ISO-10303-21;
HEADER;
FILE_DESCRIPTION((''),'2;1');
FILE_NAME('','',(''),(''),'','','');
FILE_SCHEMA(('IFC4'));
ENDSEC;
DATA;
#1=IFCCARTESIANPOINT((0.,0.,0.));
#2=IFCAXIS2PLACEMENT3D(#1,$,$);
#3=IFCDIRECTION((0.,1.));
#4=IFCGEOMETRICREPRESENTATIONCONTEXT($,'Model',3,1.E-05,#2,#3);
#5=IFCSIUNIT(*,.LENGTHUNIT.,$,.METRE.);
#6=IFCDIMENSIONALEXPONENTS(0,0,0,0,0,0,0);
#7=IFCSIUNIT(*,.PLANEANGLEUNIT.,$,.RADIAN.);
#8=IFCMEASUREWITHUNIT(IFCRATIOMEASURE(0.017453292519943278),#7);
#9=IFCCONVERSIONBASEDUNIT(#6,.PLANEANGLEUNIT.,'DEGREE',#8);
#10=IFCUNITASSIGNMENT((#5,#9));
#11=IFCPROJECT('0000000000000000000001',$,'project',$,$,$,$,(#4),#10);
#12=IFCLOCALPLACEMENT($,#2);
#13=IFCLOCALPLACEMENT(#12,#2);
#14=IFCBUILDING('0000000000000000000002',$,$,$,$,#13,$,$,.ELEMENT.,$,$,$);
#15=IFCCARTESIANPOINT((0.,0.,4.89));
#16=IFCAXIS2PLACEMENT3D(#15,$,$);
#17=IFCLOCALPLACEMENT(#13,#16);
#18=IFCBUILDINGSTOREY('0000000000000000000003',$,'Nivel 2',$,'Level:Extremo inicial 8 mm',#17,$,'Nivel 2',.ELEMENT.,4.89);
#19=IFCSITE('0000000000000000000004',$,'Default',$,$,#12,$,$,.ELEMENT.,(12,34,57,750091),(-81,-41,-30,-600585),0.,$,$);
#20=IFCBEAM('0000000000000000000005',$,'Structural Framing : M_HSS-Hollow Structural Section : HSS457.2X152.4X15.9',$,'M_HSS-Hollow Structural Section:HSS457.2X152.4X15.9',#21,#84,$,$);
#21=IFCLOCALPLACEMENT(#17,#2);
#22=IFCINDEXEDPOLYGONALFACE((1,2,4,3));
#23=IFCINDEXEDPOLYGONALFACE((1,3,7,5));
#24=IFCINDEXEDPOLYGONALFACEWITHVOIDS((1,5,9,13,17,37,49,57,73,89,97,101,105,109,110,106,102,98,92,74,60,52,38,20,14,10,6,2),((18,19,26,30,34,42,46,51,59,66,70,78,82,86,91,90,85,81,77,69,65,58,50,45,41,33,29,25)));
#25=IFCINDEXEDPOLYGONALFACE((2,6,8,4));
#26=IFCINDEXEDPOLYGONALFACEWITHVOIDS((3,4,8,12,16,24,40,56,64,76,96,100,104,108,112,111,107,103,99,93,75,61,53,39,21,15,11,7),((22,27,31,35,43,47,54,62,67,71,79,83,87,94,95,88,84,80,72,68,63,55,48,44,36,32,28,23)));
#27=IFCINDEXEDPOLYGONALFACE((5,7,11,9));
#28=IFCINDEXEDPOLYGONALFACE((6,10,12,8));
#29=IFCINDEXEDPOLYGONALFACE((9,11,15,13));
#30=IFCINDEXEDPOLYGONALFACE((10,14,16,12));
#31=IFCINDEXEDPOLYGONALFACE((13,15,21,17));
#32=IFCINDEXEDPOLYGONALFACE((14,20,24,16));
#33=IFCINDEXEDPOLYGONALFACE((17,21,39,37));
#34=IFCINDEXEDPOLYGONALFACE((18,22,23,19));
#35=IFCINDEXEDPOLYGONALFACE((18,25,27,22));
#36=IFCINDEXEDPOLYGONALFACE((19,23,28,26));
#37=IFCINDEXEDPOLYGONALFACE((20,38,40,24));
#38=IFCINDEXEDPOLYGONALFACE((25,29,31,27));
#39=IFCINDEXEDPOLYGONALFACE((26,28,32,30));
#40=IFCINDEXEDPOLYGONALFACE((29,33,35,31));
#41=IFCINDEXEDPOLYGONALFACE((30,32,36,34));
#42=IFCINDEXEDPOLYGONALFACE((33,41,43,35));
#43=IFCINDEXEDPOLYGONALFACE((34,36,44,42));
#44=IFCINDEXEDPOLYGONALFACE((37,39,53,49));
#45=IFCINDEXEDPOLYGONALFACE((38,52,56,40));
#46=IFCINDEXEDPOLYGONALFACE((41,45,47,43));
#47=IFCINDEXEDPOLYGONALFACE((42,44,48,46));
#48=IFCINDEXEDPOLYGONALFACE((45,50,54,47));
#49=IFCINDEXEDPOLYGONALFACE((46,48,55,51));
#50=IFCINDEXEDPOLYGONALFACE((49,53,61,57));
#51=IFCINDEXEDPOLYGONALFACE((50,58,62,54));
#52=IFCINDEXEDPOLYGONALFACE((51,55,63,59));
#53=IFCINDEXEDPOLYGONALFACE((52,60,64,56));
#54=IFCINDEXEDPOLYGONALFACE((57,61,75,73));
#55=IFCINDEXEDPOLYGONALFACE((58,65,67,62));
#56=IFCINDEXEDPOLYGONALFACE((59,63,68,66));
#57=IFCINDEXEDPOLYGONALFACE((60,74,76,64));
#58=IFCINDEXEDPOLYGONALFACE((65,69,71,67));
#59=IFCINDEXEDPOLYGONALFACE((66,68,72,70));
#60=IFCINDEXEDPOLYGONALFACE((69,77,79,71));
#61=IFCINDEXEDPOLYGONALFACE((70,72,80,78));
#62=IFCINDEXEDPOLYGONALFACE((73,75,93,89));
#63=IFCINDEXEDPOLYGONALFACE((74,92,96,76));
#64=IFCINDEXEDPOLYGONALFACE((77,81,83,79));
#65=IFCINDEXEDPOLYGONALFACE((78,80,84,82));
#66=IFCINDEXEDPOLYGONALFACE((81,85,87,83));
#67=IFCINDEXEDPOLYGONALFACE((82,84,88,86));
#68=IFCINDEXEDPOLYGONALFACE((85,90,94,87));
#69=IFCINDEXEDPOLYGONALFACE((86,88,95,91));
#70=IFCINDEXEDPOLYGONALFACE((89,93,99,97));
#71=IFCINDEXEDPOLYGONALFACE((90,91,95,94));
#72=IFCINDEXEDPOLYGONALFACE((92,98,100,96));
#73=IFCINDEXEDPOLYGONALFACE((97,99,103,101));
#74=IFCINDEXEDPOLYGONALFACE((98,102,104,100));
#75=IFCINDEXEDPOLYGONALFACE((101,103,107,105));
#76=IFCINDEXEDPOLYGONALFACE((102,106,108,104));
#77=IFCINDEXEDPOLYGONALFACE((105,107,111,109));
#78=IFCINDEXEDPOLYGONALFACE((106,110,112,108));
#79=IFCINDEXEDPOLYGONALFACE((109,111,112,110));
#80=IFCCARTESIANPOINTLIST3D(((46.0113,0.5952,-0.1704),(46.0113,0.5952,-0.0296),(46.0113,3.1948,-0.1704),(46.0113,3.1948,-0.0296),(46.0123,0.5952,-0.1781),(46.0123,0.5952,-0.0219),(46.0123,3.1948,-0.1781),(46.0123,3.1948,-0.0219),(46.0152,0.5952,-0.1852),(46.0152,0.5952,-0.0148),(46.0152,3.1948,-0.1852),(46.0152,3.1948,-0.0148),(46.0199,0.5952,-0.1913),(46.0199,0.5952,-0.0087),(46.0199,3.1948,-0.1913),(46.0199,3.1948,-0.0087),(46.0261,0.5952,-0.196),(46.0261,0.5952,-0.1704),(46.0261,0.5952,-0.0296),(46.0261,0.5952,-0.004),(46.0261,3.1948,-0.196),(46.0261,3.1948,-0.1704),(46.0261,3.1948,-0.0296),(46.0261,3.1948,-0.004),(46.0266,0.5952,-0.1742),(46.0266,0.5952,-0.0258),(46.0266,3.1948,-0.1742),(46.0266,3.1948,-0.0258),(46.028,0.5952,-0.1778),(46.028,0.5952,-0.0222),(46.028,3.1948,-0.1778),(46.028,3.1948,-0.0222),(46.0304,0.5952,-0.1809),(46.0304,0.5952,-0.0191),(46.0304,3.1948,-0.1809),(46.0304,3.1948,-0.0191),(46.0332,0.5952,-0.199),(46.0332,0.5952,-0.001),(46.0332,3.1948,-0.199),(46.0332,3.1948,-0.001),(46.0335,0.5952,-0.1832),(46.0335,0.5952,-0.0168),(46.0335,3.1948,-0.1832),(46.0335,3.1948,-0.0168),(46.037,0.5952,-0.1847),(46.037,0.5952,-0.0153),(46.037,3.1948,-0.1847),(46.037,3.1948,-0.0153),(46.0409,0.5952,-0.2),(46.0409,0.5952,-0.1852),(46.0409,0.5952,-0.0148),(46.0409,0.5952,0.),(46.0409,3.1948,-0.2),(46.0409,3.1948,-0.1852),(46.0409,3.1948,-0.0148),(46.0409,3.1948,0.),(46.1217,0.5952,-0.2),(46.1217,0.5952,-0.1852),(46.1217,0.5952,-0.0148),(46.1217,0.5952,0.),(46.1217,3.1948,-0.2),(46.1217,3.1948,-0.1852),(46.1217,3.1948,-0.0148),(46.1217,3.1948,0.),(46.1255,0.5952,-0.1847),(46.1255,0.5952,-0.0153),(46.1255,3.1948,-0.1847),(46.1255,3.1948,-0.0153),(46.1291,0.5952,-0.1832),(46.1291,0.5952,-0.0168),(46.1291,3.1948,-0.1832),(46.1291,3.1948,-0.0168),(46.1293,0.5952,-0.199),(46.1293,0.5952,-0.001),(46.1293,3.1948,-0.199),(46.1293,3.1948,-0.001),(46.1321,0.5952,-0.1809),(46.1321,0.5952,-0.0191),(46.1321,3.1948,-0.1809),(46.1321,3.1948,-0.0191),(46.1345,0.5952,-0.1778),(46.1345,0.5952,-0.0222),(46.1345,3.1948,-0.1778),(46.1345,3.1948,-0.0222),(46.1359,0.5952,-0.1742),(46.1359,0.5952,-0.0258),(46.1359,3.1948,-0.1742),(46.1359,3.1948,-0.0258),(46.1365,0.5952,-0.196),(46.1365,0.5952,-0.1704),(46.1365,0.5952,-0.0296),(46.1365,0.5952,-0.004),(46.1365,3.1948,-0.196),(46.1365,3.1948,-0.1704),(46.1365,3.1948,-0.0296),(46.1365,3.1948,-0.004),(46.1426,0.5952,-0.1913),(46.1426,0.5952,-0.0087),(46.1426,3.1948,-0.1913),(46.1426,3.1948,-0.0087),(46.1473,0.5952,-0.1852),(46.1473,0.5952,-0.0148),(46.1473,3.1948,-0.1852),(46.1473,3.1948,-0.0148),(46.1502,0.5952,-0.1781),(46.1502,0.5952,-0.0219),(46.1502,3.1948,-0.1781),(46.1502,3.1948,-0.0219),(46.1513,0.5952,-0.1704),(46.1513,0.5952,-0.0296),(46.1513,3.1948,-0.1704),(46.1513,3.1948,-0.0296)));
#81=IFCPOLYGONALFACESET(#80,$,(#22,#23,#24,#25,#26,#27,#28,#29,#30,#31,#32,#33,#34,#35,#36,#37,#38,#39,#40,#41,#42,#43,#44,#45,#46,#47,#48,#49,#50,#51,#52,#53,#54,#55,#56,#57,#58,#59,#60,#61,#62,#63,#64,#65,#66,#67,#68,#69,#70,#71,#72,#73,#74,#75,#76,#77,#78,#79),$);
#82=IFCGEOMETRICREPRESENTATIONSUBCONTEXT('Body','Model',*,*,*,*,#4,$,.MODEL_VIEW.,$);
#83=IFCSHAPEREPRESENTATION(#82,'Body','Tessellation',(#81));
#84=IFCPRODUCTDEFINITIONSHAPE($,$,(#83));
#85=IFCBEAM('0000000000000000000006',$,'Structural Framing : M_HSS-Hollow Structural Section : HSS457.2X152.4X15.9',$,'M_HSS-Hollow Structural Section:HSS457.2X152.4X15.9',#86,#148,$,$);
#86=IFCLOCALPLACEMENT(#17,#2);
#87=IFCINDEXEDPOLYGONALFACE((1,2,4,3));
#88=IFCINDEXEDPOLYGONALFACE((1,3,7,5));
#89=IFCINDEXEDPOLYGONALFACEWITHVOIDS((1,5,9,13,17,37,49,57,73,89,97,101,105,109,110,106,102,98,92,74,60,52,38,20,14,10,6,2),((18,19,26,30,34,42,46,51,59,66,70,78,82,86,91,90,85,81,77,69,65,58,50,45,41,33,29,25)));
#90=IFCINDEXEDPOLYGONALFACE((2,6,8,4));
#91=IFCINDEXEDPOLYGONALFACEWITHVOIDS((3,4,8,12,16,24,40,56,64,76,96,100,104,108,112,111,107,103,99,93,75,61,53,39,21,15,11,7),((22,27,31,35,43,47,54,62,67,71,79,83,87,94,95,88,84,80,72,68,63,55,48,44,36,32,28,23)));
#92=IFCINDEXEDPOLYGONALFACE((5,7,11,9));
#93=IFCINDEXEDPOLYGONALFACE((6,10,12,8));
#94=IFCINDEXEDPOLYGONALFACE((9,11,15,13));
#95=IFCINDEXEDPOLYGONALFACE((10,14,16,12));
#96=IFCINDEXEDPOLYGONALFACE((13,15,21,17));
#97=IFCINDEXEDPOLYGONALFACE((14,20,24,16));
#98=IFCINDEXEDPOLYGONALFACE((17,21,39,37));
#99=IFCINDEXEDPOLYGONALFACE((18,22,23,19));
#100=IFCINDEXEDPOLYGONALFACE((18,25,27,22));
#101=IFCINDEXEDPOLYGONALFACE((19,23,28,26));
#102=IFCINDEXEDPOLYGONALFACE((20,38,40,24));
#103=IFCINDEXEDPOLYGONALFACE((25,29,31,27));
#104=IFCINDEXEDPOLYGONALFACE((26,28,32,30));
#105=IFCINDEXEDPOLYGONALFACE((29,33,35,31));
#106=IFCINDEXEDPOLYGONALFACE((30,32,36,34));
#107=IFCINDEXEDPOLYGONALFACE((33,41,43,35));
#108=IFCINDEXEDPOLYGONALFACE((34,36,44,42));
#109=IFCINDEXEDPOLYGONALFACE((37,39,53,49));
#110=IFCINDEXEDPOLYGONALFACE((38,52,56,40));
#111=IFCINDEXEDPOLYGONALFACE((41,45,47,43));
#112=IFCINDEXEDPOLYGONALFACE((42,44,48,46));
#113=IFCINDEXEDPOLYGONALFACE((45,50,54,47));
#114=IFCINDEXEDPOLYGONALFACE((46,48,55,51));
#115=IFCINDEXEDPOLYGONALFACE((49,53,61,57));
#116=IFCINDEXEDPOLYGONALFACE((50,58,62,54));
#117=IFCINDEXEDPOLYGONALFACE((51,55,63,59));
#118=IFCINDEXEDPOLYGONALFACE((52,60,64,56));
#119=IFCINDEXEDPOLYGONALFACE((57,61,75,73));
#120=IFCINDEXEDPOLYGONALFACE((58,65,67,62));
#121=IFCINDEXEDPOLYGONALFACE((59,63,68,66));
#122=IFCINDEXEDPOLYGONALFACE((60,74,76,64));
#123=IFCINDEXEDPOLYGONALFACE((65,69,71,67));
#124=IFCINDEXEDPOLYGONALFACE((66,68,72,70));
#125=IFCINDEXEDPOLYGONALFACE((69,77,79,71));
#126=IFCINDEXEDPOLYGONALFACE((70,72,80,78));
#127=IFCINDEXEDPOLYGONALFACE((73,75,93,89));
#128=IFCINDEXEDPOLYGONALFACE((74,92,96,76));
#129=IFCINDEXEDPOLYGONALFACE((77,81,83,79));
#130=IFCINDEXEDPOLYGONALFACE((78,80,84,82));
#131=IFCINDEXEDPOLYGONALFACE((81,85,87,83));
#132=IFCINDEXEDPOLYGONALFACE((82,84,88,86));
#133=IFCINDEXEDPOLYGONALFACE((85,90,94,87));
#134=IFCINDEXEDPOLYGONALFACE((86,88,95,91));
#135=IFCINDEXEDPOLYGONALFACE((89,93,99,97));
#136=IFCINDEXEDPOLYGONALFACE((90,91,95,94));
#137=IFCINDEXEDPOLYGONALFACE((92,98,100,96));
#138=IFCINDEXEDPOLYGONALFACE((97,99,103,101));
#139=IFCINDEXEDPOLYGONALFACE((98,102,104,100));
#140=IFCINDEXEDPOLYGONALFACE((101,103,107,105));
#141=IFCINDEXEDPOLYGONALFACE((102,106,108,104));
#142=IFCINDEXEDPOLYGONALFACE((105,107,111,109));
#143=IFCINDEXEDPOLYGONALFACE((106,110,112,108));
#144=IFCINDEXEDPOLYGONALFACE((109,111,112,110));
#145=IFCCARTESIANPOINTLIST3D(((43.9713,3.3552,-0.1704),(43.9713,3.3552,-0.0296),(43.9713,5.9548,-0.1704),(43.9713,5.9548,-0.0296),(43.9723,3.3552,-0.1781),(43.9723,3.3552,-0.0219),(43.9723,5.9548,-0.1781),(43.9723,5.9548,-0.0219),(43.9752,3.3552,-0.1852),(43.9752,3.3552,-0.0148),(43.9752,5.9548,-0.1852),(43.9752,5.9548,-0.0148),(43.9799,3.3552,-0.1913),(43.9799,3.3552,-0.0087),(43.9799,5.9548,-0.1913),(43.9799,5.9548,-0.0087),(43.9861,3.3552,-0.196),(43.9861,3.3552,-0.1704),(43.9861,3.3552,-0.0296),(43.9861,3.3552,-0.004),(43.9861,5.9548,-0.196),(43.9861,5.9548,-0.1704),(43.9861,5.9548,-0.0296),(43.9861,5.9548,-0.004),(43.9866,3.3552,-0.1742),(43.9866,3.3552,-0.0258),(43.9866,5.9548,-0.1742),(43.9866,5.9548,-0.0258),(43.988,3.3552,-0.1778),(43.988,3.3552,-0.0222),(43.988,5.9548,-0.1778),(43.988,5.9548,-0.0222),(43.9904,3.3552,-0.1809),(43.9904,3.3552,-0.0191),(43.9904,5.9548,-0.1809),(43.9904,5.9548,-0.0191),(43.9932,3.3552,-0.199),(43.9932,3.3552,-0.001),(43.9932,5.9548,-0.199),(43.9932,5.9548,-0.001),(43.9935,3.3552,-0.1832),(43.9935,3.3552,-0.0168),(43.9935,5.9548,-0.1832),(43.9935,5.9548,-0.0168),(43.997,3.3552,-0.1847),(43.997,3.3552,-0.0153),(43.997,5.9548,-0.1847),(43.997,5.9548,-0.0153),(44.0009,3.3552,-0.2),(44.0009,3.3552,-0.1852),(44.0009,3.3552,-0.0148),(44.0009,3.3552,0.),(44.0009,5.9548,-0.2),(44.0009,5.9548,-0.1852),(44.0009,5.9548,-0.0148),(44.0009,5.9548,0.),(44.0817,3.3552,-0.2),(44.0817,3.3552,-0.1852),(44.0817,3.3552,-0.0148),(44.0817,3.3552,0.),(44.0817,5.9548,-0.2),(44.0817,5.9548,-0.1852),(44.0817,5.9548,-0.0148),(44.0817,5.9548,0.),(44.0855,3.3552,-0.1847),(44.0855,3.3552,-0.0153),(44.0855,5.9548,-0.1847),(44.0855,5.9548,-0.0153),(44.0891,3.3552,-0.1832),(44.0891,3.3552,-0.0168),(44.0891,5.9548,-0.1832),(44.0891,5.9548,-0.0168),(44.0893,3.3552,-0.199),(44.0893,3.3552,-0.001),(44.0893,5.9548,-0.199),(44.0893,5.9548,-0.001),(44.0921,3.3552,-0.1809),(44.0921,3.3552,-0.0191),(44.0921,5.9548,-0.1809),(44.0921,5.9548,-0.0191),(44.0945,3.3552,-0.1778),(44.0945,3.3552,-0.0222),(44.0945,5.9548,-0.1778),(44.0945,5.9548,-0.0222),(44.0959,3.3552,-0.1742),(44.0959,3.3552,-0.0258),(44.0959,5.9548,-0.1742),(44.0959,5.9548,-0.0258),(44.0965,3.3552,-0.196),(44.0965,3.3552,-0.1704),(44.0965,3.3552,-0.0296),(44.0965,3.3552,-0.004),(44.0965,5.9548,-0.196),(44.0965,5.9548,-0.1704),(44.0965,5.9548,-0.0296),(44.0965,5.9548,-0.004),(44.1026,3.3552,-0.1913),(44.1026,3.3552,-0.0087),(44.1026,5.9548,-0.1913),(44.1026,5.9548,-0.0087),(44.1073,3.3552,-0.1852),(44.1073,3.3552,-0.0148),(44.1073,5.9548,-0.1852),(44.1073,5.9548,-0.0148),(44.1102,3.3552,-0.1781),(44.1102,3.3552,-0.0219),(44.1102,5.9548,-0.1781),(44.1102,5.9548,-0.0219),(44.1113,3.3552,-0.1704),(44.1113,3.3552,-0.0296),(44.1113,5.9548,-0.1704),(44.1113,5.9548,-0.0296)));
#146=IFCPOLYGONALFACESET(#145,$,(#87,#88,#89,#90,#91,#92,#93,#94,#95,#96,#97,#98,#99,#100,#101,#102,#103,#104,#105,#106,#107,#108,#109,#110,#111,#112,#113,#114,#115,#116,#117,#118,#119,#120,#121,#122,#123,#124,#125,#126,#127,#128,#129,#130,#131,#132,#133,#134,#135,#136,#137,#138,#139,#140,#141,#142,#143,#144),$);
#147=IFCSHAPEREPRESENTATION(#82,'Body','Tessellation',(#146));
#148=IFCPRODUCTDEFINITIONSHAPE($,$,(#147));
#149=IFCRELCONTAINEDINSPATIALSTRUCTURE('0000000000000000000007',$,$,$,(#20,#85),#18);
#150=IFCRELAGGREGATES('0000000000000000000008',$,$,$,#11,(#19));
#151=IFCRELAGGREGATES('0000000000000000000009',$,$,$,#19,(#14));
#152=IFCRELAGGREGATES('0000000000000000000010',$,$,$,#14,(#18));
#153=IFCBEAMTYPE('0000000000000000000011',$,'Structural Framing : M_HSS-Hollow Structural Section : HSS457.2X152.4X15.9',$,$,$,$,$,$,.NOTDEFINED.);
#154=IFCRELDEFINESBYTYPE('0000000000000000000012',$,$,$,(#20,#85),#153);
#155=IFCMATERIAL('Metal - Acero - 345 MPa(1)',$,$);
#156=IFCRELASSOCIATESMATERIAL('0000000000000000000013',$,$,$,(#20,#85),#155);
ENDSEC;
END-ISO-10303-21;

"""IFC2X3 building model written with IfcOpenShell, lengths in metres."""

from ifc_helpers import new_model, entity, si_unit, converted_unit, direction, frame, frame_2d, origin, place, context, subcontext, project, spatial, polyline, circle_curve, parameter, trimmed, segment, composite_curve, outline, extrude, material, type_object, element, save


model = new_model("IFC2X3")

# Units and contexts
model_context = context("Model", 3, precision=1e-05, world=origin(), true_north=direction((0.0, 1.0)))
body_context = subcontext(model_context, "Body", "Model", "MODEL_VIEW")
ifc_project = project(units=[si_unit("LENGTHUNIT", "METRE"), converted_unit("PLANEANGLEUNIT", "DEGREE", entity("IfcRatioMeasure", 0.017453292519943278), si_unit("PLANEANGLEUNIT", "RADIAN"), dimensions=[0, 0, 0, 0, 0, 0, 0])], contexts=[model_context])

# Site, building, storey
site_placement = place(None, origin())
site = spatial("IfcSite", under=ifc_project, at=site_placement, Name="Default", CompositionType="ELEMENT", RefLatitude=(12, 34, 57, 750091), RefLongitude=(-81, -41, -30, -600585), RefElevation=0.0)
building_placement = place(site_placement, origin())
building = spatial("IfcBuilding", under=site, at=building_placement, CompositionType="ELEMENT")
storey_placement = place(building_placement, frame((0.0, 0.0, 4.89)))
storey = spatial("IfcBuildingStorey", under=building, at=storey_placement, Name="Nivel 2", ObjectType="Level:Extremo inicial 8 mm", LongName="Nivel 2", CompositionType="ELEMENT", Elevation=4.89)

# Shared definitions
ifc_material_1 = material(Name="Metal - Acero - 345 MPa(1)")

# Beams
beam_type_1 = type_object("IfcBeamType", Name="Structural Framing : M_HSS-Hollow Structural Section : HSS457.2X152.4X15.9", PredefinedType="NOTDEFINED")
beam_1_placement = place(storey_placement, frame((46.0813, 3.275, 0.0), z_axis=(0.0, 0.0, 1.0), x_axis=(0.0, -1.0, 0.0)))
element("IfcBeam", 1, at=beam_1_placement, inside=storey, type_object=beam_type_1, material=ifc_material_1, Name="Structural Framing : M_HSS-Hollow Structural Section : HSS457.2X152.4X15.9", ObjectType="M_HSS-Hollow Structural Section:HSS457.2X152.4X15.9", context=body_context, shape_type="SweptSolid", body=[
    extrude(outline(composite_curve([segment(polyline([(-0.0704, -0.07), (0.0704, -0.07)]), True, "CONTINUOUS"), segment(trimmed(circle_curve(frame_2d((0.0704, -0.0404), x_axis=(0.0, 1.0)), 0.0296), [parameter(180.0)], [parameter(270.0)], True, "PARAMETER"), True, "CONTINUOUS"), segment(polyline([(0.1, -0.0404), (0.1, 0.0404)]), True, "CONTINUOUS"), segment(trimmed(circle_curve(frame_2d((0.0704, 0.0404), x_axis=(0.0, 1.0)), 0.0296), [parameter(270.0)], [parameter(0.0)], True, "PARAMETER"), True, "CONTINUOUS"), segment(polyline([(0.0704, 0.07), (-0.0704, 0.07)]), True, "CONTINUOUS"), segment(trimmed(circle_curve(frame_2d((-0.0704, 0.0404), x_axis=(0.0, 1.0)), 0.0296), [parameter(360.0)], [parameter(90.0)], True, "PARAMETER"), True, "CONTINUOUS"), segment(polyline([(-0.1, 0.0404), (-0.1, -0.0404)]), True, "CONTINUOUS"), segment(trimmed(circle_curve(frame_2d((-0.0704, -0.0404), x_axis=(0.0, 1.0)), 0.0296), [parameter(90.0)], [parameter(180.0)], True, "PARAMETER"), True, "CONTINUOUS")], self_intersect=False), holes=[composite_curve([segment(trimmed(circle_curve(frame_2d((-0.0704, 0.0404), x_axis=(0.0, 1.0)), 0.0148), [parameter(360.0)], [parameter(90.0)], True, "PARAMETER"), False, "CONTINUOUS"), segment(polyline([(-0.0704, 0.0552), (0.0704, 0.0552)]), True, "CONTINUOUS"), segment(trimmed(circle_curve(frame_2d((0.0704, 0.0404), x_axis=(0.0, 1.0)), 0.0148), [parameter(270.0)], [parameter(0.0)], True, "PARAMETER"), False, "CONTINUOUS"), segment(polyline([(0.0852, 0.0404), (0.0852, -0.0404)]), True, "CONTINUOUS"), segment(trimmed(circle_curve(frame_2d((0.0704, -0.0404), x_axis=(0.0, 1.0)), 0.0148), [parameter(180.0)], [parameter(270.0)], True, "PARAMETER"), False, "CONTINUOUS"), segment(polyline([(0.0704, -0.0552), (-0.0704, -0.0552)]), True, "CONTINUOUS"), segment(trimmed(circle_curve(frame_2d((-0.0704, -0.0404), x_axis=(0.0, 1.0)), 0.0148), [parameter(90.0)], [parameter(180.0)], True, "PARAMETER"), False, "CONTINUOUS"), segment(polyline([(-0.0852, -0.0404), (-0.0852, 0.0404)]), True, "CONTINUOUS")], self_intersect=False)]), frame((0.0802, 0.0, -0.1), z_axis=(1.0, 0.0, 0.0), x_axis=(0.0, 0.0, -1.0)), (0.0, 0.0, 1.0), 2.5996),
])
beam_2_placement = place(storey_placement, frame((44.0413, 3.275, 0.0), z_axis=(0.0, 0.0, 1.0), x_axis=(0.0, 1.0, 0.0)))
element("IfcBeam", 2, at=beam_2_placement, inside=storey, type_object=beam_type_1, material=ifc_material_1, Name="Structural Framing : M_HSS-Hollow Structural Section : HSS457.2X152.4X15.9", ObjectType="M_HSS-Hollow Structural Section:HSS457.2X152.4X15.9", context=body_context, shape_type="SweptSolid", body=[
    extrude(outline(composite_curve([segment(polyline([(-0.0704, -0.07), (0.0704, -0.07)]), True, "CONTINUOUS"), segment(trimmed(circle_curve(frame_2d((0.0704, -0.0404), x_axis=(0.0, 1.0)), 0.0296), [parameter(180.0)], [parameter(270.0)], True, "PARAMETER"), True, "CONTINUOUS"), segment(polyline([(0.1, -0.0404), (0.1, 0.0404)]), True, "CONTINUOUS"), segment(trimmed(circle_curve(frame_2d((0.0704, 0.0404), x_axis=(0.0, 1.0)), 0.0296), [parameter(270.0)], [parameter(0.0)], True, "PARAMETER"), True, "CONTINUOUS"), segment(polyline([(0.0704, 0.07), (-0.0704, 0.07)]), True, "CONTINUOUS"), segment(trimmed(circle_curve(frame_2d((-0.0704, 0.0404), x_axis=(0.0, 1.0)), 0.0296), [parameter(360.0)], [parameter(90.0)], True, "PARAMETER"), True, "CONTINUOUS"), segment(polyline([(-0.1, 0.0404), (-0.1, -0.0404)]), True, "CONTINUOUS"), segment(trimmed(circle_curve(frame_2d((-0.0704, -0.0404), x_axis=(0.0, 1.0)), 0.0296), [parameter(90.0)], [parameter(180.0)], True, "PARAMETER"), True, "CONTINUOUS")], self_intersect=False), holes=[composite_curve([segment(trimmed(circle_curve(frame_2d((-0.0704, 0.0404), x_axis=(0.0, 1.0)), 0.0148), [parameter(360.0)], [parameter(90.0)], True, "PARAMETER"), False, "CONTINUOUS"), segment(polyline([(-0.0704, 0.0552), (0.0704, 0.0552)]), True, "CONTINUOUS"), segment(trimmed(circle_curve(frame_2d((0.0704, 0.0404), x_axis=(0.0, 1.0)), 0.0148), [parameter(270.0)], [parameter(0.0)], True, "PARAMETER"), False, "CONTINUOUS"), segment(polyline([(0.0852, 0.0404), (0.0852, -0.0404)]), True, "CONTINUOUS"), segment(trimmed(circle_curve(frame_2d((0.0704, -0.0404), x_axis=(0.0, 1.0)), 0.0148), [parameter(180.0)], [parameter(270.0)], True, "PARAMETER"), False, "CONTINUOUS"), segment(polyline([(0.0704, -0.0552), (-0.0704, -0.0552)]), True, "CONTINUOUS"), segment(trimmed(circle_curve(frame_2d((-0.0704, -0.0404), x_axis=(0.0, 1.0)), 0.0148), [parameter(90.0)], [parameter(180.0)], True, "PARAMETER"), False, "CONTINUOUS"), segment(polyline([(-0.0852, -0.0404), (-0.0852, 0.0404)]), True, "CONTINUOUS")], self_intersect=False)]), frame((0.0802, 0.0, -0.1), z_axis=(1.0, 0.0, 0.0), x_axis=(0.0, 0.0, -1.0)), (0.0, 0.0, 1.0), 2.5996),
])

save(model, "model.ifc")
